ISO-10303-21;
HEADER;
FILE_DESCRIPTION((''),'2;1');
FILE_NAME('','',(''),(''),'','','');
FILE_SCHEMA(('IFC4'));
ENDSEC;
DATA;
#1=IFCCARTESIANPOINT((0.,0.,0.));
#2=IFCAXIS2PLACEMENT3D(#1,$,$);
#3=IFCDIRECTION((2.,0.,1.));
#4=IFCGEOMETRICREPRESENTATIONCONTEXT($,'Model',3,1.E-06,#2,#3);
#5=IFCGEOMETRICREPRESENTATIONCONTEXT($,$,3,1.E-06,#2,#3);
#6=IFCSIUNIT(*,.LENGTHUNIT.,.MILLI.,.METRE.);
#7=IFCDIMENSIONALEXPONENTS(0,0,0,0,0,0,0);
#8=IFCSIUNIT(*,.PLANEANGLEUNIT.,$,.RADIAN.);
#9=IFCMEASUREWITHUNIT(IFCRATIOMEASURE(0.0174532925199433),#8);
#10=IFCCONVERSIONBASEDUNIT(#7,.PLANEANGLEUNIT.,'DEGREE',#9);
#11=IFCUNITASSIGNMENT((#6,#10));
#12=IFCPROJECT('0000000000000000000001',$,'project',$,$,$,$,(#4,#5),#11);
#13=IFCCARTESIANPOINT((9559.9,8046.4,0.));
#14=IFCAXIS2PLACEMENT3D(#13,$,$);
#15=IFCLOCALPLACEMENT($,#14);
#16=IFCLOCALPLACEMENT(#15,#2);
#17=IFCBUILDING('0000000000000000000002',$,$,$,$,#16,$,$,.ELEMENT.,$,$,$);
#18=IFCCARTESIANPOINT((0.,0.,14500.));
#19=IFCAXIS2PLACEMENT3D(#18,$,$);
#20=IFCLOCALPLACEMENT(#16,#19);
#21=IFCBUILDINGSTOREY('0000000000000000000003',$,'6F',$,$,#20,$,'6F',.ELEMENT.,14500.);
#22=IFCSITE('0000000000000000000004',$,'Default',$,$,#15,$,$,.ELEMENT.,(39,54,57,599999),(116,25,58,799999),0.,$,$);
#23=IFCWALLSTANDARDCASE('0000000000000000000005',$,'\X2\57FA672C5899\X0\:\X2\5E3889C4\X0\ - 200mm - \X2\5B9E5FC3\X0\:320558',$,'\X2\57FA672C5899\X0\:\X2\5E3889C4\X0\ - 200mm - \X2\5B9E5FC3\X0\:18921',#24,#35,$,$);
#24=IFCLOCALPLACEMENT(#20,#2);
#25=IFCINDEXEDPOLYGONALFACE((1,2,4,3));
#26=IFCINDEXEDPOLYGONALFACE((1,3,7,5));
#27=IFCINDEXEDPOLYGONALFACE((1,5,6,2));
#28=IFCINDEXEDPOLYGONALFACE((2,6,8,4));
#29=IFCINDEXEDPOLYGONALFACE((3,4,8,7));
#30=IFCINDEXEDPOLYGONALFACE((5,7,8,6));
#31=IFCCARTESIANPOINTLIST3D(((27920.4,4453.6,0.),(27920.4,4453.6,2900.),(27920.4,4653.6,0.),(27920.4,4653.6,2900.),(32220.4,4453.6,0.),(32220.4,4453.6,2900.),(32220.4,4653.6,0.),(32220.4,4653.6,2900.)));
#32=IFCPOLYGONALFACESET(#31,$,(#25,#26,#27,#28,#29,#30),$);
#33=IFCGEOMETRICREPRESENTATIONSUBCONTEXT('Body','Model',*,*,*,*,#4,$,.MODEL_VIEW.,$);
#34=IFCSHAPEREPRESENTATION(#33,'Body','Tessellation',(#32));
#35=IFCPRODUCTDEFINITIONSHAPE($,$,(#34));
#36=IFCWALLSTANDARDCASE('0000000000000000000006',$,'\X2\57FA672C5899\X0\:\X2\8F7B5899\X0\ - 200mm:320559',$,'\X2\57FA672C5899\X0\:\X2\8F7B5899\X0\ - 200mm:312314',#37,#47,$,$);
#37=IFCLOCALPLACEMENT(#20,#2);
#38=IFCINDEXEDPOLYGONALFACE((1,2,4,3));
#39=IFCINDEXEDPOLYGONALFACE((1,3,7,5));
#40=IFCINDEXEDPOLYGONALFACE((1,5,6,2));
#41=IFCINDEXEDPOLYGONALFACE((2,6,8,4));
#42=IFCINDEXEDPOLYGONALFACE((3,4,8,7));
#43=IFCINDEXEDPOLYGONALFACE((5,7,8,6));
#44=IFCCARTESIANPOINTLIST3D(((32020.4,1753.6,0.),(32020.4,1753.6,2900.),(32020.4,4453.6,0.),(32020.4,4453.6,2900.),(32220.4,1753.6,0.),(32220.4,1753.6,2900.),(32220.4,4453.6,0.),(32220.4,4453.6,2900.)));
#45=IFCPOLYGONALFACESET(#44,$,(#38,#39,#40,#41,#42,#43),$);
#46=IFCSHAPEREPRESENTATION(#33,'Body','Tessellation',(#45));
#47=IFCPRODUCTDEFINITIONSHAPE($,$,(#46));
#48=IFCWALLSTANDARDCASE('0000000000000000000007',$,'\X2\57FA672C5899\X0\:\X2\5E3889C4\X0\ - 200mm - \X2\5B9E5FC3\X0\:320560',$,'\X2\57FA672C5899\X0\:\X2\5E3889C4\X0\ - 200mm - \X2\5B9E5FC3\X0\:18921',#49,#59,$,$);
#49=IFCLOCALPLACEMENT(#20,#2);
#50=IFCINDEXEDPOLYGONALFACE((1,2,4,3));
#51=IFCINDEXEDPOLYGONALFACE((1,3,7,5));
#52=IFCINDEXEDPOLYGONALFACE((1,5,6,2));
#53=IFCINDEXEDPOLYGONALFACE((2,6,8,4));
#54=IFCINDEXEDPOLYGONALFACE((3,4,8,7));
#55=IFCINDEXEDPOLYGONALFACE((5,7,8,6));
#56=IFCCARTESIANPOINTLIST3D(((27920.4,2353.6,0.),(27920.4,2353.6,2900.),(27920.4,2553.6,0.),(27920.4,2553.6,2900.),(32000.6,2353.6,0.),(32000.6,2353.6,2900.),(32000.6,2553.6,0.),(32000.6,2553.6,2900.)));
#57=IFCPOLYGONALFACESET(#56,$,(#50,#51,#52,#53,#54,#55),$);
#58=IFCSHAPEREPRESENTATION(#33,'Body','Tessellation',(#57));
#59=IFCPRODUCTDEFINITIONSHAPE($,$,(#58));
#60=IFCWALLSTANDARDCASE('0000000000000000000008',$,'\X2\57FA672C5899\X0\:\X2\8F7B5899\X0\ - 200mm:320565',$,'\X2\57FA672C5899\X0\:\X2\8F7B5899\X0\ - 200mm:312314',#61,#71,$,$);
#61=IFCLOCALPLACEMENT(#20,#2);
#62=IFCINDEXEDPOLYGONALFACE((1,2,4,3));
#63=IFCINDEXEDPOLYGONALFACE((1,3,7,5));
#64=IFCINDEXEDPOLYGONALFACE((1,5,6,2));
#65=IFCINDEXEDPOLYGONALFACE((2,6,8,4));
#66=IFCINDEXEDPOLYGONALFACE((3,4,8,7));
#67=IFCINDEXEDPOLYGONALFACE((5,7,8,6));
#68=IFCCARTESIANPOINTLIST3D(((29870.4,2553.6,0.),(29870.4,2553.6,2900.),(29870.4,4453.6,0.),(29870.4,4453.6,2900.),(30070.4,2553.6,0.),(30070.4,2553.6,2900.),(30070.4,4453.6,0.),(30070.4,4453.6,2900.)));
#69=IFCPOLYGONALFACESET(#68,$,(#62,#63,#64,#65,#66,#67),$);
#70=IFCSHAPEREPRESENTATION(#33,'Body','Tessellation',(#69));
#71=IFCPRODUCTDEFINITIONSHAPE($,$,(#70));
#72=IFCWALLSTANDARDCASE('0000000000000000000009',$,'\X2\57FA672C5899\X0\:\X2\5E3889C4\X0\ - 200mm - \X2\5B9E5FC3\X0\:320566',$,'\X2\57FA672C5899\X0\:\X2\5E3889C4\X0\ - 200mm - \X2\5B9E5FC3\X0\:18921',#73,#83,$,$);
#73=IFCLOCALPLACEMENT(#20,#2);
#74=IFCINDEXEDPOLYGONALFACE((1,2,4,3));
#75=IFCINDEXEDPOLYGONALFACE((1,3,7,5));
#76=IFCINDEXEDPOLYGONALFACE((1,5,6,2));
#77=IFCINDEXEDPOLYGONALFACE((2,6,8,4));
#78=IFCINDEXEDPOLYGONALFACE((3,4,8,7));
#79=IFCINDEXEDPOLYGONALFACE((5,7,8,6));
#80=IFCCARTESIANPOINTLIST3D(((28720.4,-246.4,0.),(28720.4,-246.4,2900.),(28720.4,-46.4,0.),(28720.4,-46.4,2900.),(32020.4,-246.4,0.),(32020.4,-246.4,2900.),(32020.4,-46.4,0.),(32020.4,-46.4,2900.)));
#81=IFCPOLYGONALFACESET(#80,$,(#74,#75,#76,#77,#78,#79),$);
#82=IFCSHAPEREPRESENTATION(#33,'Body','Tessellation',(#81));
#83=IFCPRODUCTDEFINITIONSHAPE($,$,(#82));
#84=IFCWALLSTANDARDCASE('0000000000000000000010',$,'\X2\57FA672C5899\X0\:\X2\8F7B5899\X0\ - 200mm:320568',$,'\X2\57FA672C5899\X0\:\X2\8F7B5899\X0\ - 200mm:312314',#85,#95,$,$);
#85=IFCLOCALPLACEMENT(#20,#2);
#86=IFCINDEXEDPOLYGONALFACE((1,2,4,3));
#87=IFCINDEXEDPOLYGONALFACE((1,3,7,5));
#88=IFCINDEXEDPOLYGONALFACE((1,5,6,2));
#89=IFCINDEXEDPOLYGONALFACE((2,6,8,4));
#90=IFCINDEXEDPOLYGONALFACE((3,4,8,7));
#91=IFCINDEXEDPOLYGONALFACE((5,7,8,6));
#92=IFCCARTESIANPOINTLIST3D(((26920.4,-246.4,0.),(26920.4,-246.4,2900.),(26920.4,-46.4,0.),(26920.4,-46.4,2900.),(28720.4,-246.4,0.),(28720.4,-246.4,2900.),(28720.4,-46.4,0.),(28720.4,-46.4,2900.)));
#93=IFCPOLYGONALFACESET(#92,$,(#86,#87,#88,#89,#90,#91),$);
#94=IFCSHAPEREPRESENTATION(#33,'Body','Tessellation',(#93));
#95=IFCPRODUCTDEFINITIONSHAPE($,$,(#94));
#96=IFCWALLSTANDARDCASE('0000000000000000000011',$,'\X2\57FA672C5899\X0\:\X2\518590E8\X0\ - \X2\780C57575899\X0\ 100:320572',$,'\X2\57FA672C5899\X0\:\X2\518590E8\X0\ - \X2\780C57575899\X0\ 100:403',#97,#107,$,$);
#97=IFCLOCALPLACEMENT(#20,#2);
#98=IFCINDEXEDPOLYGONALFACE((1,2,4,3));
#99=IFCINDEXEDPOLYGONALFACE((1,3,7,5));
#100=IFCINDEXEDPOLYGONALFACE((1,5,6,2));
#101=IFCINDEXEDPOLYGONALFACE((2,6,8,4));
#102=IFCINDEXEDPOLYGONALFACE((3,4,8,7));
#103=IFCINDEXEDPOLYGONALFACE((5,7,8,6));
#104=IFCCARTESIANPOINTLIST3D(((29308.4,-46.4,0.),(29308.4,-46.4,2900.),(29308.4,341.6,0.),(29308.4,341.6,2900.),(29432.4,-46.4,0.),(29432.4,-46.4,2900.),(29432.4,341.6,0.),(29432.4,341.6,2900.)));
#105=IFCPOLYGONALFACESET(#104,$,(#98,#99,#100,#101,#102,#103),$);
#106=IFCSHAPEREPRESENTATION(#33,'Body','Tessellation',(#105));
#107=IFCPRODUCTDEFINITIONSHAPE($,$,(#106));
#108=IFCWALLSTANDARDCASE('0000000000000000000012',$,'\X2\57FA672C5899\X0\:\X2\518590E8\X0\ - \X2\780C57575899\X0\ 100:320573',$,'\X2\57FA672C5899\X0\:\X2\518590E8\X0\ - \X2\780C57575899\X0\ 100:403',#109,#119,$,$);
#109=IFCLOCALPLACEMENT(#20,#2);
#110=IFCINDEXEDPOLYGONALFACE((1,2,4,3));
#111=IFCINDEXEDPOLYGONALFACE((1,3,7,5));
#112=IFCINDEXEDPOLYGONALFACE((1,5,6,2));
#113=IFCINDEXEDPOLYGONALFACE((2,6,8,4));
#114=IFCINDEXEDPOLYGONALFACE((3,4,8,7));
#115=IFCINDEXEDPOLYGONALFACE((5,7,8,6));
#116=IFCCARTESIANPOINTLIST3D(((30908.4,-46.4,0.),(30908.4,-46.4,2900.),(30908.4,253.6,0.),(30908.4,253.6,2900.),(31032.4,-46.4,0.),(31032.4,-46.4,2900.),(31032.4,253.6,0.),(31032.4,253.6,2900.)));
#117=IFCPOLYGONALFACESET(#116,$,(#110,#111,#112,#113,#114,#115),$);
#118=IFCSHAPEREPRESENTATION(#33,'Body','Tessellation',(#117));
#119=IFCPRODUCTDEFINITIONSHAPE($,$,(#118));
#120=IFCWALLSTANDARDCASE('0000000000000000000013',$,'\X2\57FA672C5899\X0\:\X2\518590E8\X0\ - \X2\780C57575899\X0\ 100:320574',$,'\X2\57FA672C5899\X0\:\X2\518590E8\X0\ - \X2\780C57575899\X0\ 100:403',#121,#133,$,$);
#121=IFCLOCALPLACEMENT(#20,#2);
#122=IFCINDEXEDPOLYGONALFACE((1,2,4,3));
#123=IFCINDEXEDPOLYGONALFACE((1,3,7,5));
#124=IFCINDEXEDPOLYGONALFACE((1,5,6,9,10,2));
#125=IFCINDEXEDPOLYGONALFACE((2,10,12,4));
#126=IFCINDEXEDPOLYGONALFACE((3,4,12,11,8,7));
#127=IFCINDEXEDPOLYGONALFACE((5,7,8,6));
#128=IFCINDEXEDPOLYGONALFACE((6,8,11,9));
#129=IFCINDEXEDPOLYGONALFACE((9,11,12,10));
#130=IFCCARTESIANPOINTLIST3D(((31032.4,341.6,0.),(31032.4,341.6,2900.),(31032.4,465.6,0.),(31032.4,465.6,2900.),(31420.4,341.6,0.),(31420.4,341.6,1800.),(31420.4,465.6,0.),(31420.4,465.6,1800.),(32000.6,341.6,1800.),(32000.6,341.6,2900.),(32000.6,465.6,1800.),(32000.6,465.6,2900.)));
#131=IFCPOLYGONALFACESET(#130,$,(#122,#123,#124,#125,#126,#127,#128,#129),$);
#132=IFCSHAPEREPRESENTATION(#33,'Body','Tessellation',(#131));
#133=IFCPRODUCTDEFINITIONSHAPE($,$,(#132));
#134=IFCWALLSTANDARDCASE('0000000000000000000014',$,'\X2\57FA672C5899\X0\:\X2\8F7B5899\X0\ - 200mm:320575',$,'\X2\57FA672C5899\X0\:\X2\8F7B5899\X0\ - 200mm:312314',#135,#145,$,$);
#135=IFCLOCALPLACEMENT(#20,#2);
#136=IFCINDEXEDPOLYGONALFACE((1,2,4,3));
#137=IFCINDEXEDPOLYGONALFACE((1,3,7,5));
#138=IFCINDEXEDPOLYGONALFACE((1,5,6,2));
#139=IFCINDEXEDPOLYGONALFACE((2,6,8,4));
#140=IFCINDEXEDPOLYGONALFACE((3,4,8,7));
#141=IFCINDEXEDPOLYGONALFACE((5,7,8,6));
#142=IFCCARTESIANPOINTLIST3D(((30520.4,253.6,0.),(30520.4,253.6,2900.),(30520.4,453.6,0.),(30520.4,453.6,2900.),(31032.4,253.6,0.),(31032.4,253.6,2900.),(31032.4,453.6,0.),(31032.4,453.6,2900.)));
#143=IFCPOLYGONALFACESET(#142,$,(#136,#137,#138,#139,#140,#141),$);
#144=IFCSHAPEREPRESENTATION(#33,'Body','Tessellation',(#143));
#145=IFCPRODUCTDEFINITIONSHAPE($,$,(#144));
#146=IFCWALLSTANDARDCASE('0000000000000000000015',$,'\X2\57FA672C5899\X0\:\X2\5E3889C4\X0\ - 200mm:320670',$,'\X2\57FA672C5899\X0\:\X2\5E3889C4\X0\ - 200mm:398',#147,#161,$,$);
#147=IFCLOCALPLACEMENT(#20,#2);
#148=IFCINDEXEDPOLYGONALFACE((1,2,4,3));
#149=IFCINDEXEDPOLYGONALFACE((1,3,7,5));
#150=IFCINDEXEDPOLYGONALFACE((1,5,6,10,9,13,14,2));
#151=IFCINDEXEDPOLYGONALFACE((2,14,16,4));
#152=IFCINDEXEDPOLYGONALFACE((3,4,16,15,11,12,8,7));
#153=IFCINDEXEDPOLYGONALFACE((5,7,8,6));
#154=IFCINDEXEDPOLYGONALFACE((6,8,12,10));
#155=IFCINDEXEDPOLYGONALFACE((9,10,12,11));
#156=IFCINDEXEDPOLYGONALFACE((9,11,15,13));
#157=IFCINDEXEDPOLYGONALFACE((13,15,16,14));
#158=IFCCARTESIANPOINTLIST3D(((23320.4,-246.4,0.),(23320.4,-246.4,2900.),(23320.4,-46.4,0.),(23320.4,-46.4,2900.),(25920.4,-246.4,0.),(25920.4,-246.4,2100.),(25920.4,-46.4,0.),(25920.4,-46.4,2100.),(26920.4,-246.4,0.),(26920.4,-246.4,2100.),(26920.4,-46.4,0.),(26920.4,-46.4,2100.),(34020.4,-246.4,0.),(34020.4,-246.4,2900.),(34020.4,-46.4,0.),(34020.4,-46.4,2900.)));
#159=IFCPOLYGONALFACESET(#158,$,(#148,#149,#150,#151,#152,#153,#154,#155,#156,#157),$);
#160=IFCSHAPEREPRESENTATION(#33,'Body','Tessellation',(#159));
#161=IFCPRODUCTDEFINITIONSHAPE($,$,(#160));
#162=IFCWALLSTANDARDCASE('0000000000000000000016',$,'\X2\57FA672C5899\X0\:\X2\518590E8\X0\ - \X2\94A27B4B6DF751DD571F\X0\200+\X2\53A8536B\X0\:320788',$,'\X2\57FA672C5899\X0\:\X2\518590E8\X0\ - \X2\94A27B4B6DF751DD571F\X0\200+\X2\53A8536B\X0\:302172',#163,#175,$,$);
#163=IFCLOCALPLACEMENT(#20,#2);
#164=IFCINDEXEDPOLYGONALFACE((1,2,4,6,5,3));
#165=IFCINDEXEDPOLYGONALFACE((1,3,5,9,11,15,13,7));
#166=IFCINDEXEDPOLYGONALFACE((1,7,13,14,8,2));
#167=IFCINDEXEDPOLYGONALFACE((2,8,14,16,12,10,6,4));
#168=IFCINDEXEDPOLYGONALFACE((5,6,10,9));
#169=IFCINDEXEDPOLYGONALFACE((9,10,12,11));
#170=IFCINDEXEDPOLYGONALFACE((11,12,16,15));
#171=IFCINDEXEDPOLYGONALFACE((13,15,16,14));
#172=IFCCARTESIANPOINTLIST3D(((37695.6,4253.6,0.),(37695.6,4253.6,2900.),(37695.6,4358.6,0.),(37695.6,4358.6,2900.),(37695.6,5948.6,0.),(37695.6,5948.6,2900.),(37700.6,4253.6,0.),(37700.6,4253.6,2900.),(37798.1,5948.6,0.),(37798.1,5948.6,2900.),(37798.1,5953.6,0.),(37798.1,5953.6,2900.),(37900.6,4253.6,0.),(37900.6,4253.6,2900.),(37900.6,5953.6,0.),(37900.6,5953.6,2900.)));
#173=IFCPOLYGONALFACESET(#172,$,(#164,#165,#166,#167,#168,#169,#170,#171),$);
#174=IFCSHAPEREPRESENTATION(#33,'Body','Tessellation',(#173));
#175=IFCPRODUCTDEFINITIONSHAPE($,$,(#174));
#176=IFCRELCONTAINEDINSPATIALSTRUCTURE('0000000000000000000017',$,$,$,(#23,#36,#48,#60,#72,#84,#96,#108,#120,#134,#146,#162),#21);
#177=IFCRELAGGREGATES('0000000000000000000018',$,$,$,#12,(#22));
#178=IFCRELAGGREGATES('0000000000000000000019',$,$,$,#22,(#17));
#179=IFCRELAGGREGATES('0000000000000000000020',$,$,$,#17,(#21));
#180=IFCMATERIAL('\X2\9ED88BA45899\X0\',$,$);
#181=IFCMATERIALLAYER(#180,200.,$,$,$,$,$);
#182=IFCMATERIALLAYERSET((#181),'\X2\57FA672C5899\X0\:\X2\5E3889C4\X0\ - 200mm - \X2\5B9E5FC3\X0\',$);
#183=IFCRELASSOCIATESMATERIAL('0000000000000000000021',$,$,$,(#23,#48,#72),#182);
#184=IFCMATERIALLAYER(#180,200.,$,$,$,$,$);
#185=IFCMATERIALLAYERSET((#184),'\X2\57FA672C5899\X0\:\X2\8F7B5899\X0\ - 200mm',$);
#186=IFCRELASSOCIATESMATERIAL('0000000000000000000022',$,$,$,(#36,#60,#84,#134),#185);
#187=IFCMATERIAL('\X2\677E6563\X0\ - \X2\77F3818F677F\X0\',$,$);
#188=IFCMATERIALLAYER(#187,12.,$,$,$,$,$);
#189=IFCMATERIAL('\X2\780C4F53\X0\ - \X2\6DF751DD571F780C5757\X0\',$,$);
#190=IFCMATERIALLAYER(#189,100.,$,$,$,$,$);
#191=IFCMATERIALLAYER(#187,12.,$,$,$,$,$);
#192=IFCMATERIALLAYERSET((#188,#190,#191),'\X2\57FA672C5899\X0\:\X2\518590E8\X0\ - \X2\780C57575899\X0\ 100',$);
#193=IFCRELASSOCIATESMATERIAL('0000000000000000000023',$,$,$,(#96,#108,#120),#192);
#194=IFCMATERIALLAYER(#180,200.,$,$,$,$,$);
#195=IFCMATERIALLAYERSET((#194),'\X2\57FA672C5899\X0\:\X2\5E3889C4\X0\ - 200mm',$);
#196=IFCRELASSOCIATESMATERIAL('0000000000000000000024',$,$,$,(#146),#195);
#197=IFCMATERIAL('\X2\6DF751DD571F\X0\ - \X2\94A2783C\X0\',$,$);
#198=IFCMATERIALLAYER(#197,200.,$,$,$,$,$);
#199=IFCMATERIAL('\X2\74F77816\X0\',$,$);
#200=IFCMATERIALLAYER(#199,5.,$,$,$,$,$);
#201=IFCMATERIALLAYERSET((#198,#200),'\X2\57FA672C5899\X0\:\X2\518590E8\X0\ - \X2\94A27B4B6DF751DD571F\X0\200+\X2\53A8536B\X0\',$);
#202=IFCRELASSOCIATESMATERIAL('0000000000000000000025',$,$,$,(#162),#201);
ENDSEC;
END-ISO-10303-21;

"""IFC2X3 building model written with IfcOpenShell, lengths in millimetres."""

from ifc_helpers import new_model, entity, si_unit, converted_unit, direction, frame, frame_2d, origin, place, context, subcontext, project, spatial, polyline, rectangle, outline, extrude, material, layer, layer_set, layer_usage, element, save


model = new_model("IFC2X3")

# Units and contexts
model_context = context("Model", 3, precision=1e-06, world=origin(), true_north=direction((2.0, 0.0, 1.0)))
context_of_model = context(None, 3, precision=1e-06, world=origin(), true_north=direction((2.0, 0.0, 1.0)))
body_context = subcontext(model_context, "Body", "Model", "MODEL_VIEW")
ifc_project = project(units=[si_unit("LENGTHUNIT", "METRE", prefix="MILLI"), converted_unit("PLANEANGLEUNIT", "DEGREE", entity("IfcRatioMeasure", 0.0174532925199433), si_unit("PLANEANGLEUNIT", "RADIAN"), dimensions=[0, 0, 0, 0, 0, 0, 0])], contexts=[model_context, context_of_model])

# Site, building, storey
site_placement = place(None, frame((9559.9, 8046.4, 0.0)))
site = spatial("IfcSite", under=ifc_project, at=site_placement, Name="Default", CompositionType="ELEMENT", RefLatitude=(39, 54, 57, 599999), RefLongitude=(116, 25, 58, 799999), RefElevation=0.0)
building_placement = place(site_placement, origin())
building = spatial("IfcBuilding", under=site, at=building_placement, CompositionType="ELEMENT")
storey_placement = place(building_placement, frame((0.0, 0.0, 14500.0)))
storey = spatial("IfcBuildingStorey", under=building, at=storey_placement, Name="6F", LongName="6F", CompositionType="ELEMENT", Elevation=14500.0)

# Walls
ifc_material_1 = material(Name="默认墙")
ifc_layer_1 = layer(ifc_material_1, 200.0)
ifc_layer_set_1 = layer_set([ifc_layer_1], Name="基本墙:常规 - 200mm - 实心")
ifc_layer_usage_1 = layer_usage(ifc_layer_set_1, "AXIS2", "POSITIVE", -100.0)
wall_1_placement = place(storey_placement, frame((32220.4, 4553.6, 0.0), z_axis=(0.0, 0.0, 1.0), x_axis=(-1.0, 0.0, 0.0)))
element("IfcWallStandardCase", 1, at=wall_1_placement, inside=storey, material=ifc_layer_usage_1, Name="基本墙:常规 - 200mm - 实心:320558", ObjectType="基本墙:常规 - 200mm - 实心:18921", context=body_context, shape_type="SweptSolid", body=[
    extrude(rectangle(XDim=4300.0, YDim=200.0, at=frame_2d((2150.0, 0.0), x_axis=(-1.0, 0.0))), origin(), (0.0, 0.0, 1.0), 2900.0),
])
ifc_layer_2 = layer(ifc_material_1, 200.0)
ifc_layer_set_2 = layer_set([ifc_layer_2], Name="基本墙:轻墙 - 200mm")
ifc_layer_usage_2 = layer_usage(ifc_layer_set_2, "AXIS2", "POSITIVE", -100.0)
wall_2_placement = place(storey_placement, frame((32120.4, 4453.6, 0.0), z_axis=(0.0, 0.0, 1.0), x_axis=(0.0, -1.0, 0.0)))
element("IfcWallStandardCase", 2, at=wall_2_placement, inside=storey, material=ifc_layer_usage_2, Name="基本墙:轻墙 - 200mm:320559", ObjectType="基本墙:轻墙 - 200mm:312314", context=body_context, shape_type="SweptSolid", body=[
    extrude(rectangle(XDim=2700.0, YDim=200.0, at=frame_2d((1350.0, 0.0), x_axis=(-1.0, 0.0))), origin(), (0.0, 0.0, 1.0), 2900.0),
])
ifc_layer_usage_3 = layer_usage(ifc_layer_set_1, "AXIS2", "POSITIVE", -100.0)
wall_3_placement = place(storey_placement, frame((27920.4, 2453.6, 0.0)))
element("IfcWallStandardCase", 3, at=wall_3_placement, inside=storey, material=ifc_layer_usage_3, Name="基本墙:常规 - 200mm - 实心:320560", ObjectType="基本墙:常规 - 200mm - 实心:18921", context=body_context, shape_type="SweptSolid", body=[
    extrude(rectangle(XDim=4080.2, YDim=200.0, at=frame_2d((2040.1, 0.0), x_axis=(-1.0, 0.0))), origin(), (0.0, 0.0, 1.0), 2900.0),
])
ifc_layer_usage_4 = layer_usage(ifc_layer_set_2, "AXIS2", "POSITIVE", -100.0)
wall_4_placement = place(storey_placement, frame((29970.4, 4453.6, 0.0), z_axis=(0.0, 0.0, 1.0), x_axis=(0.0, -1.0, 0.0)))
element("IfcWallStandardCase", 4, at=wall_4_placement, inside=storey, material=ifc_layer_usage_4, Name="基本墙:轻墙 - 200mm:320565", ObjectType="基本墙:轻墙 - 200mm:312314", context=body_context, shape_type="SweptSolid", body=[
    extrude(rectangle(XDim=1900.0, YDim=200.0, at=frame_2d((950.0, 0.0), x_axis=(-1.0, 0.0))), origin(), (0.0, 0.0, 1.0), 2900.0),
])
ifc_layer_usage_5 = layer_usage(ifc_layer_set_1, "AXIS2", "POSITIVE", -100.0)
wall_5_placement = place(storey_placement, frame((32020.4, -146.4, 0.0), z_axis=(0.0, 0.0, 1.0), x_axis=(-1.0, 0.0, 0.0)))
element("IfcWallStandardCase", 5, at=wall_5_placement, inside=storey, material=ifc_layer_usage_5, Name="基本墙:常规 - 200mm - 实心:320566", ObjectType="基本墙:常规 - 200mm - 实心:18921", context=body_context, shape_type="SweptSolid", body=[
    extrude(rectangle(XDim=3300.0, YDim=200.0, at=frame_2d((1650.0, 0.0), x_axis=(-1.0, 0.0))), origin(), (0.0, 0.0, 1.0), 2900.0),
])
ifc_layer_usage_6 = layer_usage(ifc_layer_set_2, "AXIS2", "POSITIVE", -100.0)
wall_6_placement = place(storey_placement, frame((28720.4, -146.4, 0.0), z_axis=(0.0, 0.0, 1.0), x_axis=(-1.0, 0.0, 0.0)))
element("IfcWallStandardCase", 6, at=wall_6_placement, inside=storey, material=ifc_layer_usage_6, Name="基本墙:轻墙 - 200mm:320568", ObjectType="基本墙:轻墙 - 200mm:312314", context=body_context, shape_type="SweptSolid", body=[
    extrude(rectangle(XDim=1800.0, YDim=200.0, at=frame_2d((900.0, 0.0), x_axis=(-1.0, 0.0))), origin(), (0.0, 0.0, 1.0), 2900.0),
])
ifc_material_2 = material(Name="松散 - 石膏板")
ifc_layer_3 = layer(ifc_material_2, 12.0)
ifc_material_3 = material(Name="砌体 - 混凝土砌块")
ifc_layer_4 = layer(ifc_material_3, 100.0)
ifc_layer_5 = layer(ifc_material_2, 12.0)
ifc_layer_set_3 = layer_set([ifc_layer_3, ifc_layer_4, ifc_layer_5], Name="基本墙:内部 - 砌块墙 100")
ifc_layer_usage_7 = layer_usage(ifc_layer_set_3, "AXIS2", "POSITIVE", -62.0)
wall_7_placement = place(storey_placement, frame((29370.4, 341.6, 0.0), z_axis=(0.0, 0.0, 1.0), x_axis=(0.0, -1.0, 0.0)))
element("IfcWallStandardCase", 7, at=wall_7_placement, inside=storey, material=ifc_layer_usage_7, Name="基本墙:内部 - 砌块墙 100:320572", ObjectType="基本墙:内部 - 砌块墙 100:403", context=body_context, shape_type="SweptSolid", body=[
    extrude(rectangle(XDim=388.0, YDim=124.0, at=frame_2d((194.0, 0.0), x_axis=(-1.0, 0.0))), origin(), (0.0, 0.0, 1.0), 2900.0),
])
ifc_layer_usage_8 = layer_usage(ifc_layer_set_3, "AXIS2", "POSITIVE", -62.0)
wall_8_placement = place(storey_placement, frame((30970.4, -46.4, 0.0), z_axis=(0.0, 0.0, 1.0), x_axis=(0.0, 1.0, 0.0)))
element("IfcWallStandardCase", 8, at=wall_8_placement, inside=storey, material=ifc_layer_usage_8, Name="基本墙:内部 - 砌块墙 100:320573", ObjectType="基本墙:内部 - 砌块墙 100:403", context=body_context, shape_type="SweptSolid", body=[
    extrude(rectangle(XDim=300.0, YDim=124.0, at=frame_2d((150.0, 0.0), x_axis=(-1.0, 0.0))), origin(), (0.0, 0.0, 1.0), 2900.0),
])

# Wall, opening
ifc_layer_usage_9 = layer_usage(ifc_layer_set_3, "AXIS2", "POSITIVE", -62.0)
wall_9_placement = place(storey_placement, frame((31032.4, 403.6, 0.0)))
wall_9 = element("IfcWallStandardCase", 9, at=wall_9_placement, inside=storey, material=ifc_layer_usage_9, Name="基本墙:内部 - 砌块墙 100:320574", ObjectType="基本墙:内部 - 砌块墙 100:403", context=body_context, shape_type="SweptSolid", body=[
    extrude(rectangle(XDim=968.2, YDim=124.0, at=frame_2d((484.1, 0.0), x_axis=(-1.0, 0.0))), origin(), (0.0, 0.0, 1.0), 2900.0),
])
opening_1_placement = place(wall_9_placement, frame((388.0, -62.0, 0.0)))
element("IfcOpeningElement", 10, at=opening_1_placement, cuts=wall_9, ObjectType="Opening", context=body_context, shape_type="SweptSolid", body=[
    extrude(rectangle(XDim=1800.0, YDim=600.0, at=frame_2d((900.0, 300.0), x_axis=(1.0, 0.0))), frame((0.0, 0.0, 0.0), z_axis=(0.0, 1.0, 0.0), x_axis=(0.0, 0.0, 1.0)), (0.0, 0.0, 1.0), 124.0),
])

# Wall
ifc_layer_usage_10 = layer_usage(ifc_layer_set_2, "AXIS2", "POSITIVE", -100.0)
wall_10_placement = place(storey_placement, frame((31032.4, 353.6, 0.0), z_axis=(0.0, 0.0, 1.0), x_axis=(-1.0, 0.0, 0.0)))
element("IfcWallStandardCase", 11, at=wall_10_placement, inside=storey, material=ifc_layer_usage_10, Name="基本墙:轻墙 - 200mm:320575", ObjectType="基本墙:轻墙 - 200mm:312314", context=body_context, shape_type="SweptSolid", body=[
    extrude(rectangle(XDim=512.0, YDim=200.0, at=frame_2d((256.0, 0.0), x_axis=(-1.0, 0.0))), origin(), (0.0, 0.0, 1.0), 2900.0),
])

# Wall, opening
ifc_layer_6 = layer(ifc_material_1, 200.0)
ifc_layer_set_4 = layer_set([ifc_layer_6], Name="基本墙:常规 - 200mm")
ifc_layer_usage_11 = layer_usage(ifc_layer_set_4, "AXIS2", "POSITIVE", -100.0)
wall_11_placement = place(storey_placement, frame((34020.4, -146.4, 0.0), z_axis=(0.0, 0.0, 1.0), x_axis=(-1.0, 0.0, 0.0)))
wall_11 = element("IfcWallStandardCase", 12, at=wall_11_placement, inside=storey, material=ifc_layer_usage_11, Name="基本墙:常规 - 200mm:320670", ObjectType="基本墙:常规 - 200mm:398", context=body_context, shape_type="SweptSolid", body=[
    extrude(rectangle(XDim=10700.0, YDim=200.0, at=frame_2d((5350.0, 0.0), x_axis=(-1.0, 0.0))), origin(), (0.0, 0.0, 1.0), 2900.0),
])
opening_2_placement = place(wall_11_placement, frame((8100.0, 100.0, 0.0)))
element("IfcOpeningElement", 13, at=opening_2_placement, cuts=wall_11, ObjectType="Opening", context=body_context, shape_type="SweptSolid", body=[
    extrude(rectangle(XDim=2100.0, YDim=1000.0, at=frame_2d((1050.0, 500.0), x_axis=(1.0, 0.0))), frame((0.0, 0.0, 0.0), z_axis=(0.0, -1.0, 0.0), x_axis=(0.0, 0.0, 1.0)), (0.0, 0.0, 1.0), 200.0),
])

# Wall
ifc_material_4 = material(Name="混凝土 - 钢砼")
ifc_layer_7 = layer(ifc_material_4, 200.0)
ifc_material_5 = material(Name="瓷砖")
ifc_layer_8 = layer(ifc_material_5, 5.0)
ifc_layer_set_5 = layer_set([ifc_layer_7, ifc_layer_8], Name="基本墙:内部 - 钢筋混凝土200+厨卫")
ifc_layer_usage_12 = layer_usage(ifc_layer_set_5, "AXIS2", "NEGATIVE", 102.5)
wall_12_placement = place(storey_placement, frame((37798.1, 5953.6, 0.0), z_axis=(0.0, 0.0, 1.0), x_axis=(0.0, -1.0, 0.0)))
element("IfcWallStandardCase", 14, at=wall_12_placement, inside=storey, material=ifc_layer_usage_12, Name="基本墙:内部 - 钢筋混凝土200+厨卫:320788", ObjectType="基本墙:内部 - 钢筋混凝土200+厨卫:302172", context=body_context, shape_type="SweptSolid", body=[
    extrude(outline(polyline([(1700.0, -102.5), (1700.0, -97.5), (1700.0, 102.5), (0.0, 102.5), (0.0, 0.0), (5.0, 0.0), (5.0, -102.5), (1595.0, -102.5), (1700.0, -102.5)])), origin(), (0.0, 0.0, 1.0), 2900.0),
])

save(model, "model.ifc")
